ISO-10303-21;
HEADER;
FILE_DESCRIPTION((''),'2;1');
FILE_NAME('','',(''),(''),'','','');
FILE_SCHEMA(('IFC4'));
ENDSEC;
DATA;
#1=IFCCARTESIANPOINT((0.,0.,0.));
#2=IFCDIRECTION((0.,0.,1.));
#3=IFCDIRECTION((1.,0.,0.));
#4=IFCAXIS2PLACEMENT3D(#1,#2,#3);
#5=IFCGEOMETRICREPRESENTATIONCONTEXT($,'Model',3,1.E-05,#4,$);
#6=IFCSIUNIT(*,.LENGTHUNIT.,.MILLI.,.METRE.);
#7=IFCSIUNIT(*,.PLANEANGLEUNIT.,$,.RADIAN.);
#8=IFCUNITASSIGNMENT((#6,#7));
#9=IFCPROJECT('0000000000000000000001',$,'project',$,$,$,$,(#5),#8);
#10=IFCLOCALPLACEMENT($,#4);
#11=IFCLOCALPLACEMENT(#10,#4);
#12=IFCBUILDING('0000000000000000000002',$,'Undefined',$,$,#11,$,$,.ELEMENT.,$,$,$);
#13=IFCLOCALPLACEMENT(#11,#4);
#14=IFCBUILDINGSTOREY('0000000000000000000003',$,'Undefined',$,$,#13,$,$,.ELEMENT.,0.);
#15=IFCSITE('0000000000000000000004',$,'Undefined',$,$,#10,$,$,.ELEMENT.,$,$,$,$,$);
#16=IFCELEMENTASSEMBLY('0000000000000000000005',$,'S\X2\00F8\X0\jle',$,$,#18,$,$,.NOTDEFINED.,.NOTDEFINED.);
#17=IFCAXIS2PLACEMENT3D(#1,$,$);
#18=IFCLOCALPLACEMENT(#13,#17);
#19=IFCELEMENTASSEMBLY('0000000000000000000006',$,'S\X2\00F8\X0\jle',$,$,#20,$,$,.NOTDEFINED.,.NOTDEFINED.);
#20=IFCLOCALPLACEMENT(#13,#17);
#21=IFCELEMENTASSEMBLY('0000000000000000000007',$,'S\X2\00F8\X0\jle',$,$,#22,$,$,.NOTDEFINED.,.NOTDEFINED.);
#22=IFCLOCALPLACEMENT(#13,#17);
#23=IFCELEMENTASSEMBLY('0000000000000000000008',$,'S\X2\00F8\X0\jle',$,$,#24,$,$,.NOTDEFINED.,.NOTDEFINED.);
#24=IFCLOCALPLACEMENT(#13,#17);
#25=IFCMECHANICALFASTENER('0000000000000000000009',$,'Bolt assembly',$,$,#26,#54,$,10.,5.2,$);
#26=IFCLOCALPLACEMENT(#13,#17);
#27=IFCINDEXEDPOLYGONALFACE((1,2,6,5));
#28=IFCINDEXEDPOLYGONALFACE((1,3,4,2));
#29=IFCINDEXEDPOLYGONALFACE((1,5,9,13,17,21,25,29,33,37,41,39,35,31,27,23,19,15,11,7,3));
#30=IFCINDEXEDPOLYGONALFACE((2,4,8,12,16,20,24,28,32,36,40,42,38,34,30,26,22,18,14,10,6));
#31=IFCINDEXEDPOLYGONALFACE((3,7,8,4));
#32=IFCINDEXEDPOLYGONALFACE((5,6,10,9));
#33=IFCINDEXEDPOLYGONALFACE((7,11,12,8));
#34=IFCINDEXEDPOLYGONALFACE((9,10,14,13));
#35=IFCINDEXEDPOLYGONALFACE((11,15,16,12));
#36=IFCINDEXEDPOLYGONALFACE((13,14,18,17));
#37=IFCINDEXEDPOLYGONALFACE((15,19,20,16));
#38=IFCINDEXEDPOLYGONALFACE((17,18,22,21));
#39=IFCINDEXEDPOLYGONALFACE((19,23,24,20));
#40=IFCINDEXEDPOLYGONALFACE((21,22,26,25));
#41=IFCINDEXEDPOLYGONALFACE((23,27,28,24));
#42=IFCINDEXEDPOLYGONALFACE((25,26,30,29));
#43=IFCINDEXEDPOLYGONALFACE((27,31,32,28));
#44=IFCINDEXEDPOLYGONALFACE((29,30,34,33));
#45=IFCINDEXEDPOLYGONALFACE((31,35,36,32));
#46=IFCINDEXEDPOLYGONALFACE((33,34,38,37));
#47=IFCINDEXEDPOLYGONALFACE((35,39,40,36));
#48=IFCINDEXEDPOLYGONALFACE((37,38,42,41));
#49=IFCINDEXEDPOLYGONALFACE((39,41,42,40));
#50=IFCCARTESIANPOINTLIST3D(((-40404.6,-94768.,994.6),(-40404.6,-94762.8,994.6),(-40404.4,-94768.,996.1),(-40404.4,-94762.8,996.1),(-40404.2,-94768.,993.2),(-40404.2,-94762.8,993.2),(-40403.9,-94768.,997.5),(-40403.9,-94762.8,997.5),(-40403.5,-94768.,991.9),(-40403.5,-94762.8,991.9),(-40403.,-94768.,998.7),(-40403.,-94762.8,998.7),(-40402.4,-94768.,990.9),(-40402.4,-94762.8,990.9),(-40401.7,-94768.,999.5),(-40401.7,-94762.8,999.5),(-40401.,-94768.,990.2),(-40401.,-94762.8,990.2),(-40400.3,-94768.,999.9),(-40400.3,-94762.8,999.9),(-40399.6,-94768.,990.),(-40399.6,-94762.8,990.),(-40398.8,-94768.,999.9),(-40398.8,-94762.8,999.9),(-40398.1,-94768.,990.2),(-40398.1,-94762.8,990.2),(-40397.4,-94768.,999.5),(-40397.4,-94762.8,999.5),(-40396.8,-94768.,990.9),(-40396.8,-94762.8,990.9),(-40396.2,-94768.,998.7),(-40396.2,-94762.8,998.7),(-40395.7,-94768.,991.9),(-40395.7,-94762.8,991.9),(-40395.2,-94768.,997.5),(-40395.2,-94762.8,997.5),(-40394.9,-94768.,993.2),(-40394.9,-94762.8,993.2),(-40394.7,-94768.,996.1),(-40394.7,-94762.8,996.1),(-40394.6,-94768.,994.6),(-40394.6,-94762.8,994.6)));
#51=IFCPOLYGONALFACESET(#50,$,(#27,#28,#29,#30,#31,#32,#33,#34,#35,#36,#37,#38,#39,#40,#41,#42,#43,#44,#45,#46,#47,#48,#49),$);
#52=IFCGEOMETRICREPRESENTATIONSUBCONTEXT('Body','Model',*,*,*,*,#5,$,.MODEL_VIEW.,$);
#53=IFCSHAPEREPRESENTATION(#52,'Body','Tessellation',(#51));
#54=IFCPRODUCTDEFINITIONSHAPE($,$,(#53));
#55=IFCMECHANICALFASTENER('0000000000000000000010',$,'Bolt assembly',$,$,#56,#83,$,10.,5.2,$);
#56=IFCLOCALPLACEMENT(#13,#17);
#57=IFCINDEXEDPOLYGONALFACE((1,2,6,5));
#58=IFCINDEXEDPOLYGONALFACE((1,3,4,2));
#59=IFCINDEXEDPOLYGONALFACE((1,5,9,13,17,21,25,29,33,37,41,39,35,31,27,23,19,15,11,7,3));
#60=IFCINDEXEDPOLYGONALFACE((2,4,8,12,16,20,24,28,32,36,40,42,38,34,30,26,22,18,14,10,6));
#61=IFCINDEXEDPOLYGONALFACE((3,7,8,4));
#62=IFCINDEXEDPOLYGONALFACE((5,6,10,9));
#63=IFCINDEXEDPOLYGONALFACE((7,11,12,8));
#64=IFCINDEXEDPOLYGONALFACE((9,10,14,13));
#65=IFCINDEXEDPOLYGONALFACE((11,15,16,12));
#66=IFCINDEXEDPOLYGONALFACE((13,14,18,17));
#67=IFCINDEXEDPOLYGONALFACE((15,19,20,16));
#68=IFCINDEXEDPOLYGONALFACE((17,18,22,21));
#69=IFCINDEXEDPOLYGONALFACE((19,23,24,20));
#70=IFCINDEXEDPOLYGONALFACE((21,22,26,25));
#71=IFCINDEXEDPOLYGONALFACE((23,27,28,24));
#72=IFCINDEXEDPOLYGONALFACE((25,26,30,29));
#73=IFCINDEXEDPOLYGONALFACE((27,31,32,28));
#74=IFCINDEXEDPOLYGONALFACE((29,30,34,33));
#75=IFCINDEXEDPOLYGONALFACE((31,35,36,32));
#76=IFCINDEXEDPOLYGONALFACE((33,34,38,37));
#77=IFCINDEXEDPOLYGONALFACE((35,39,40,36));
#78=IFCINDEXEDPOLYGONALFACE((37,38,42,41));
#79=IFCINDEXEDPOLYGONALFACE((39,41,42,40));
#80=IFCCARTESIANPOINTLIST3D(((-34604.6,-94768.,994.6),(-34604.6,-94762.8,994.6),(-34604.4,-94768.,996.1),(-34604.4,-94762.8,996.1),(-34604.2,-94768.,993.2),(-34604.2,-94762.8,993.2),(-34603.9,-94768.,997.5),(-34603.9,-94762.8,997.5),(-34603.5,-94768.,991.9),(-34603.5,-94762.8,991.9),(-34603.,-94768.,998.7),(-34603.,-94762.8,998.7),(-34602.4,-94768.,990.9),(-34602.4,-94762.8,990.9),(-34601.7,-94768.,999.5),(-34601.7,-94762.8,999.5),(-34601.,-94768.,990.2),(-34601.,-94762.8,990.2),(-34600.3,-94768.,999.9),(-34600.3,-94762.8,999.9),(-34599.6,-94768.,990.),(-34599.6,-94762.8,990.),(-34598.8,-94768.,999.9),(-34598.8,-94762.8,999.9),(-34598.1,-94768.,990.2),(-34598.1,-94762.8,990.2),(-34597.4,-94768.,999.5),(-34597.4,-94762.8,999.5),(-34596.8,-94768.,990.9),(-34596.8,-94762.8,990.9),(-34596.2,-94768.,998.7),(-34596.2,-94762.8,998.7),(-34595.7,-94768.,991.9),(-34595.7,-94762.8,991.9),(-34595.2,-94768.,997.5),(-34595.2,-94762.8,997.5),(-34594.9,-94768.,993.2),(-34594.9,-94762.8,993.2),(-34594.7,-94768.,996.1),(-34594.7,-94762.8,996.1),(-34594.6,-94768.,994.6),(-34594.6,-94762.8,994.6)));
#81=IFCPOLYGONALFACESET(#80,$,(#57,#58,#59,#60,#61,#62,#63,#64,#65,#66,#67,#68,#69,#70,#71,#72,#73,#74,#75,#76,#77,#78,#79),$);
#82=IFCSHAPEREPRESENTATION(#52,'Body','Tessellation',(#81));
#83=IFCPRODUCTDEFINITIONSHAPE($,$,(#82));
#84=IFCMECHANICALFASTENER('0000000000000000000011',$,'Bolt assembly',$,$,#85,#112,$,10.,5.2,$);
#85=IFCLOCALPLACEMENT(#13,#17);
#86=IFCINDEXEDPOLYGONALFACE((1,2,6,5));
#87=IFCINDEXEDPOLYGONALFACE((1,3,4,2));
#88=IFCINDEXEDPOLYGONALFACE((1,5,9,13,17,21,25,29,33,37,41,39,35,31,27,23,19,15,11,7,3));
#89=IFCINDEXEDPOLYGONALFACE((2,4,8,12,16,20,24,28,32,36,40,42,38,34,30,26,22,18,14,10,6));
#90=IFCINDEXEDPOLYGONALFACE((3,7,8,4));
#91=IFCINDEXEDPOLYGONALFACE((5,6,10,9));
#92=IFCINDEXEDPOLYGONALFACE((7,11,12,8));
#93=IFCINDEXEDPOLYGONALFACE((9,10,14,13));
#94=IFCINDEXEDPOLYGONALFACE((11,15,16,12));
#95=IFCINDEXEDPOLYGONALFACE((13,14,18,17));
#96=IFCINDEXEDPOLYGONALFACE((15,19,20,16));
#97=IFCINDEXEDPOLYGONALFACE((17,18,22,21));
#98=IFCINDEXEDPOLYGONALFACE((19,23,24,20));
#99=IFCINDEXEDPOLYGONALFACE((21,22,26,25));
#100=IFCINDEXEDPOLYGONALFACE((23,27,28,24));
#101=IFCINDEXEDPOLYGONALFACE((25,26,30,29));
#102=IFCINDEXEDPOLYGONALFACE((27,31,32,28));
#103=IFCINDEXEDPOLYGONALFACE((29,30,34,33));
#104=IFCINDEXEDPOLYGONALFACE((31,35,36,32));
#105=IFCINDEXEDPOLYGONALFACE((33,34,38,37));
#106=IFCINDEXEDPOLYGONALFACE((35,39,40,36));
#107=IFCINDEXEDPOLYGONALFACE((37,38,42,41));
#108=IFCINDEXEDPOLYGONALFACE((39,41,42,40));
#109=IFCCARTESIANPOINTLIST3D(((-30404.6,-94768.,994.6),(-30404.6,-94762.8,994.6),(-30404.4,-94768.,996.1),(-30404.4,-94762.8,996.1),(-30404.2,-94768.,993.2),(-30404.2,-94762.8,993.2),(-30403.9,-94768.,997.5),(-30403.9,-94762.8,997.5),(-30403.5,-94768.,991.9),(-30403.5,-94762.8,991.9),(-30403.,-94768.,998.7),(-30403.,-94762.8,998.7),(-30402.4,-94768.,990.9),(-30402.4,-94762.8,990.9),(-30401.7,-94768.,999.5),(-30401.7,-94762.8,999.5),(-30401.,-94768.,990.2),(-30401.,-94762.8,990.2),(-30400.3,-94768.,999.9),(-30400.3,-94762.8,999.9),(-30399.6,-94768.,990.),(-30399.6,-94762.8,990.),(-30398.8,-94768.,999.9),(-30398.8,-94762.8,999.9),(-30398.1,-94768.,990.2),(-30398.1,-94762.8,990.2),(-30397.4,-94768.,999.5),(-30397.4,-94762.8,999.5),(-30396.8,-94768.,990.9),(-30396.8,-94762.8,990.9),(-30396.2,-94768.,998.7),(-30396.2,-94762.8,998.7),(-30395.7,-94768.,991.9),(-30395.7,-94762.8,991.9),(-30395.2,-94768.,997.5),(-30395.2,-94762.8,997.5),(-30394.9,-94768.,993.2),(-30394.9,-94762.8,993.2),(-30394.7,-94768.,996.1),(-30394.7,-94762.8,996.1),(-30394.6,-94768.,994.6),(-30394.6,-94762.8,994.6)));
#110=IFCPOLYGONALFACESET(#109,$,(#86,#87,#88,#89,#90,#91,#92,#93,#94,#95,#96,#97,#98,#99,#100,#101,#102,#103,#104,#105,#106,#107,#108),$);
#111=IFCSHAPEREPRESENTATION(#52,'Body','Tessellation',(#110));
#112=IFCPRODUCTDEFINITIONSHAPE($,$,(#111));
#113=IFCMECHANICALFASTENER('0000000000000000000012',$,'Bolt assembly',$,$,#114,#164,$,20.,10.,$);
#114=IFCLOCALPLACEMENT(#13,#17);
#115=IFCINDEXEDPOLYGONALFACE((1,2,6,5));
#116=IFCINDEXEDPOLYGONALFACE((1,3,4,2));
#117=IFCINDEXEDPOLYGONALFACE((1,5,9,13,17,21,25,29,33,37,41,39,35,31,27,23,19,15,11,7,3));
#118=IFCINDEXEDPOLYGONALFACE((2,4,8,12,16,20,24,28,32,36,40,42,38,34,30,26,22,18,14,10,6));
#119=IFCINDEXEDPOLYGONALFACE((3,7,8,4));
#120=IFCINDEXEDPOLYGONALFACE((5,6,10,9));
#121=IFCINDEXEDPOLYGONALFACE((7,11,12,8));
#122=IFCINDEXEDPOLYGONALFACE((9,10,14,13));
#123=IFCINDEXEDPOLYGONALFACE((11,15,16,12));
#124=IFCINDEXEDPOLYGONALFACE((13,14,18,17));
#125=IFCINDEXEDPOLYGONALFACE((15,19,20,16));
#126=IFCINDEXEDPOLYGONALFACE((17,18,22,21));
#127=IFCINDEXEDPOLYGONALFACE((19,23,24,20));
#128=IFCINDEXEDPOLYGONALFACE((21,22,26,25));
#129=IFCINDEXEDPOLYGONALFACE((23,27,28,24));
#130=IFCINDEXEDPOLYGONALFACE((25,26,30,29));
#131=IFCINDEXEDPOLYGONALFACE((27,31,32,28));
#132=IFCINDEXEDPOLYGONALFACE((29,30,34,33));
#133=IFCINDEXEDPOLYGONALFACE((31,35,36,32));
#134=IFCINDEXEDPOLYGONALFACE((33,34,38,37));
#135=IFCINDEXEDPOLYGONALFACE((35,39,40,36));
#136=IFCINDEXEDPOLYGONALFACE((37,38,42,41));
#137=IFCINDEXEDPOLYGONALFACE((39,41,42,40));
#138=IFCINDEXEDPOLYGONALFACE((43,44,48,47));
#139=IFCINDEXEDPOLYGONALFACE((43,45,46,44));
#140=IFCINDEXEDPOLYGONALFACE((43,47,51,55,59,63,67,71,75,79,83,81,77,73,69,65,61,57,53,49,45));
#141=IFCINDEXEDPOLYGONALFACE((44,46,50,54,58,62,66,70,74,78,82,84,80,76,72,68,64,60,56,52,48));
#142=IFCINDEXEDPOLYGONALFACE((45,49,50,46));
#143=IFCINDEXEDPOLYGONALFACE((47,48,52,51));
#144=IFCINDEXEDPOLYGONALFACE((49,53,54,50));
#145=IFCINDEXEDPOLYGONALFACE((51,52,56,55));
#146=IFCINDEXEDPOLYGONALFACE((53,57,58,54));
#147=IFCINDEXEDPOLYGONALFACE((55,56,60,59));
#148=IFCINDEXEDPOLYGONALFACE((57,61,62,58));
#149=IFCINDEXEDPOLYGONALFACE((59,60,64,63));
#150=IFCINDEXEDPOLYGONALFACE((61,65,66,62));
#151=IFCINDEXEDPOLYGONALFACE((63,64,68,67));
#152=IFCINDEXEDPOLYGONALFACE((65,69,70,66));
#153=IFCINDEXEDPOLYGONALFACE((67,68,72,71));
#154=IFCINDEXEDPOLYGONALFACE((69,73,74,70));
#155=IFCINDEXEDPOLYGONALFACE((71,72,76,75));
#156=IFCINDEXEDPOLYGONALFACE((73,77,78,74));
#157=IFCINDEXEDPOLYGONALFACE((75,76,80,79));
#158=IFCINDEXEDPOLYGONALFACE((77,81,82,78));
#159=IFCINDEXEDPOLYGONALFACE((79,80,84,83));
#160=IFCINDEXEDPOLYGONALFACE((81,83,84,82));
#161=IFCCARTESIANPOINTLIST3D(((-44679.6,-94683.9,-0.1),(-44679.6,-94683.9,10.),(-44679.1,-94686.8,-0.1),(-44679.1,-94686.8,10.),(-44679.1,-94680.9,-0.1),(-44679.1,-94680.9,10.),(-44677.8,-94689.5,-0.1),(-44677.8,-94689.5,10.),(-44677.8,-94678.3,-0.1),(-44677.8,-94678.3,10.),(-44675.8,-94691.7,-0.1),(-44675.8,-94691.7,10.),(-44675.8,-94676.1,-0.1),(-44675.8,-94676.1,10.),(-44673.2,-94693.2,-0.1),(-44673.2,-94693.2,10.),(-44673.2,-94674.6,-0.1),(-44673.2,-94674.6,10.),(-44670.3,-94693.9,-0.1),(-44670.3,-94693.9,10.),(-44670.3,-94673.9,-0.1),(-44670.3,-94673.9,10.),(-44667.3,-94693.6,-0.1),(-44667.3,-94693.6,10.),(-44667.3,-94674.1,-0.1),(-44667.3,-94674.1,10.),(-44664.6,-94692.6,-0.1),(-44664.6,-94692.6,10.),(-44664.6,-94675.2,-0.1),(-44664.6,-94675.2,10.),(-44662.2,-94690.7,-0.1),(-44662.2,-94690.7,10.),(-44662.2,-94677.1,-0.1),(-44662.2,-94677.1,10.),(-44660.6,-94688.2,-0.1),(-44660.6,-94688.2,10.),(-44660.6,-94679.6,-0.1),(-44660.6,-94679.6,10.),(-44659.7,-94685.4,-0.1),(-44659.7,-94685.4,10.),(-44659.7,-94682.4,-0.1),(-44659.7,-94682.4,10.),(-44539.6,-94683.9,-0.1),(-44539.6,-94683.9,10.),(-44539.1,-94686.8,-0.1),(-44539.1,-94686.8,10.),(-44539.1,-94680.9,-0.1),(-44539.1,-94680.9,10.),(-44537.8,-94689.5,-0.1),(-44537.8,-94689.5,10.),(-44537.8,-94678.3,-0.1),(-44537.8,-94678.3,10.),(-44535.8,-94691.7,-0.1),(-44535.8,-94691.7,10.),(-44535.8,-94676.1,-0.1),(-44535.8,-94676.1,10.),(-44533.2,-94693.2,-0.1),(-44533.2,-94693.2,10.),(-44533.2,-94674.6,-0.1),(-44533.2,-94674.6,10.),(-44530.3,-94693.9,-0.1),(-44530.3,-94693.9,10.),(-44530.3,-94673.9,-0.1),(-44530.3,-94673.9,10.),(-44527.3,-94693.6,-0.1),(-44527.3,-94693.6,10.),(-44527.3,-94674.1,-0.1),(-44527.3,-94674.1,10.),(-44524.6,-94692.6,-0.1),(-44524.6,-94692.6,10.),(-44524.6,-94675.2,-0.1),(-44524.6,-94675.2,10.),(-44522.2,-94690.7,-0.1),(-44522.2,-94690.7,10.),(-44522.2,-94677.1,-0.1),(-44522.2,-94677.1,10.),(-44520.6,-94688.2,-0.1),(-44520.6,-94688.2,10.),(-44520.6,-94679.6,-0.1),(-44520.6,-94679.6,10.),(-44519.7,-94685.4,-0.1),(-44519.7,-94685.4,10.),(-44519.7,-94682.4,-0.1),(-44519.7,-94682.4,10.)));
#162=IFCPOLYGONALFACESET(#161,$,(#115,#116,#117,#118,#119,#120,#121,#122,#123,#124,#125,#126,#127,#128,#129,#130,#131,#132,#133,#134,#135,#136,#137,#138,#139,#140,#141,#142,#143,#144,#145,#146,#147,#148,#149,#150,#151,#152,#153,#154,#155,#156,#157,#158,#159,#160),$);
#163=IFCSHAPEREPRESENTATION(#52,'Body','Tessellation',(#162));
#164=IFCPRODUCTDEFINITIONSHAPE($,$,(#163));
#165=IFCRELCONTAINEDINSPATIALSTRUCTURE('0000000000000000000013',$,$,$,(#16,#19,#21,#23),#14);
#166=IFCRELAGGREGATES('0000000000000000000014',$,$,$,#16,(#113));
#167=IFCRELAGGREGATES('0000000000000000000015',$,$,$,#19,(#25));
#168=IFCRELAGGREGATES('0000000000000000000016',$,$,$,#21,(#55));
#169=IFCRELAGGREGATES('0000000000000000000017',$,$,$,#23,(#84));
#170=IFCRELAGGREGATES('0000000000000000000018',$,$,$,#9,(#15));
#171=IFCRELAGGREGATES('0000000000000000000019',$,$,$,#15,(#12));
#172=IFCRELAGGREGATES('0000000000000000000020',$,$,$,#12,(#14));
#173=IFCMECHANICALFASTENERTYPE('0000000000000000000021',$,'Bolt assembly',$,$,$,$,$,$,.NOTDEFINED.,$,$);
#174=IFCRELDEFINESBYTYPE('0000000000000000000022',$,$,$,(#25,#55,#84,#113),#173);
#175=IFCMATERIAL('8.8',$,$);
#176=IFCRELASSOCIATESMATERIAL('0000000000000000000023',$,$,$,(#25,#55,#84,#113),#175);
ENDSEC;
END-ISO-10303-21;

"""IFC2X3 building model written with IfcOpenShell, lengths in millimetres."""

from ifc_helpers import new_model, si_unit, frame, origin_with_axes, origin_2d_with_axis, place, context, subcontext, project, spatial, circle, extrude, source, transform, mapped, material, type_object, element, aggregate, save


model = new_model("IFC2X3")

# Units and contexts
model_context = context("Model", 3, precision=1e-05, world=origin_with_axes())
body_context = subcontext(model_context, "Body", "Model", "MODEL_VIEW")
ifc_project = project(units=[si_unit("LENGTHUNIT", "METRE", prefix="MILLI"), si_unit("PLANEANGLEUNIT", "RADIAN")], contexts=[model_context])

# Site, building, storey
site_placement = place(None, origin_with_axes())
site = spatial("IfcSite", under=ifc_project, at=site_placement, Name="Undefined", CompositionType="ELEMENT")
building_placement = place(site_placement, origin_with_axes())
building = spatial("IfcBuilding", under=site, at=building_placement, Name="Undefined", CompositionType="ELEMENT")
storey_placement = place(building_placement, origin_with_axes())
storey = spatial("IfcBuildingStorey", under=building, at=storey_placement, Name="Undefined", CompositionType="ELEMENT", Elevation=0.0)

# Element assemblies
assembly_1_placement = place(storey_placement, origin_with_axes())
assembly_1 = element("IfcElementAssembly", 1, at=assembly_1_placement, inside=storey, Name="Søjle", AssemblyPlace="NOTDEFINED", PredefinedType="NOTDEFINED")
assembly_2_placement = place(storey_placement, origin_with_axes())
assembly_2 = element("IfcElementAssembly", 2, at=assembly_2_placement, inside=storey, Name="Søjle", AssemblyPlace="NOTDEFINED", PredefinedType="NOTDEFINED")
assembly_3_placement = place(storey_placement, origin_with_axes())
assembly_3 = element("IfcElementAssembly", 3, at=assembly_3_placement, inside=storey, Name="Søjle", AssemblyPlace="NOTDEFINED", PredefinedType="NOTDEFINED")
assembly_4_placement = place(storey_placement, origin_with_axes())
assembly_4 = element("IfcElementAssembly", 4, at=assembly_4_placement, inside=storey, Name="Søjle", AssemblyPlace="NOTDEFINED", PredefinedType="NOTDEFINED")

# Mechanical fasteners
ifc_material_1 = material(Name="8.8")
mechanical_fastener_type = type_object("IfcMechanicalFastenerType", Name="Bolt assembly")
shared_shape_1 = source(origin_with_axes(), body_context, "Body", "SweptSolid", [
    extrude(circle(Radius=5.0, at=origin_2d_with_axis()), frame((0.0, 0.0, 0.0), z_axis=(0.0, 1.0, 0.0), x_axis=(1.0, 0.0, 0.0)), (0.0, 0.0, 1.0), 5.3),
])
mechanical_fastener_1_placement = place(assembly_2_placement, frame((-40399.6, -94768.0, 995.0), z_axis=(1.0, 0.0, 0.0), x_axis=(0.0, 0.0, -1.0)))
mechanical_fastener_1 = element("IfcMechanicalFastener", 5, at=mechanical_fastener_1_placement, type_object=mechanical_fastener_type, material=ifc_material_1, Name="Bolt assembly", NominalDiameter=10.0, NominalLength=5.2, context=body_context, shape_type="MappedRepresentation", body=[
    mapped(shared_shape_1, transform((0.0, 0.0, 0.0))),
])
mechanical_fastener_2_placement = place(assembly_3_placement, frame((-34599.6, -94768.0, 995.0), z_axis=(1.0, 0.0, 0.0), x_axis=(0.0, 0.0, -1.0)))
mechanical_fastener_2 = element("IfcMechanicalFastener", 6, at=mechanical_fastener_2_placement, type_object=mechanical_fastener_type, material=ifc_material_1, Name="Bolt assembly", NominalDiameter=10.0, NominalLength=5.2, context=body_context, shape_type="MappedRepresentation", body=[
    mapped(shared_shape_1, transform((0.0, 0.0, 0.0))),
])
mechanical_fastener_3_placement = place(assembly_4_placement, frame((-30399.6, -94768.0, 995.0), z_axis=(1.0, 0.0, 0.0), x_axis=(0.0, 0.0, -1.0)))
mechanical_fastener_3 = element("IfcMechanicalFastener", 7, at=mechanical_fastener_3_placement, type_object=mechanical_fastener_type, material=ifc_material_1, Name="Bolt assembly", NominalDiameter=10.0, NominalLength=5.2, context=body_context, shape_type="MappedRepresentation", body=[
    mapped(shared_shape_1, transform((0.0, 0.0, 0.0))),
])
shared_shape_2 = source(origin_with_axes(), body_context, "Body", "SweptSolid", [
    extrude(circle(Radius=10.0, at=origin_2d_with_axis()), frame((0.0, -10.0, 0.0), z_axis=(0.0, 1.0, 0.0), x_axis=(1.0, 0.0, 0.0)), (0.0, 0.0, 1.0), 10.1),
])
mechanical_fastener_4_placement = place(assembly_1_placement, frame((-44529.6, -94683.9, 0.0), z_axis=(0.0, -1.0, 0.0), x_axis=(-1.0, 0.0, 0.0)))
mechanical_fastener_4 = element("IfcMechanicalFastener", 8, at=mechanical_fastener_4_placement, type_object=mechanical_fastener_type, material=ifc_material_1, Name="Bolt assembly", NominalDiameter=20.0, NominalLength=10.0, context=body_context, shape_type="MappedRepresentation", body=[
    mapped(shared_shape_2, transform((0.0, 0.0, 0.0))),
    mapped(shared_shape_2, transform((140.0, 0.0, 0.0))),
])
aggregate(assembly_1, [mechanical_fastener_4])
aggregate(assembly_2, [mechanical_fastener_1])
aggregate(assembly_3, [mechanical_fastener_2])
aggregate(assembly_4, [mechanical_fastener_3])

save(model, "model.ifc")
